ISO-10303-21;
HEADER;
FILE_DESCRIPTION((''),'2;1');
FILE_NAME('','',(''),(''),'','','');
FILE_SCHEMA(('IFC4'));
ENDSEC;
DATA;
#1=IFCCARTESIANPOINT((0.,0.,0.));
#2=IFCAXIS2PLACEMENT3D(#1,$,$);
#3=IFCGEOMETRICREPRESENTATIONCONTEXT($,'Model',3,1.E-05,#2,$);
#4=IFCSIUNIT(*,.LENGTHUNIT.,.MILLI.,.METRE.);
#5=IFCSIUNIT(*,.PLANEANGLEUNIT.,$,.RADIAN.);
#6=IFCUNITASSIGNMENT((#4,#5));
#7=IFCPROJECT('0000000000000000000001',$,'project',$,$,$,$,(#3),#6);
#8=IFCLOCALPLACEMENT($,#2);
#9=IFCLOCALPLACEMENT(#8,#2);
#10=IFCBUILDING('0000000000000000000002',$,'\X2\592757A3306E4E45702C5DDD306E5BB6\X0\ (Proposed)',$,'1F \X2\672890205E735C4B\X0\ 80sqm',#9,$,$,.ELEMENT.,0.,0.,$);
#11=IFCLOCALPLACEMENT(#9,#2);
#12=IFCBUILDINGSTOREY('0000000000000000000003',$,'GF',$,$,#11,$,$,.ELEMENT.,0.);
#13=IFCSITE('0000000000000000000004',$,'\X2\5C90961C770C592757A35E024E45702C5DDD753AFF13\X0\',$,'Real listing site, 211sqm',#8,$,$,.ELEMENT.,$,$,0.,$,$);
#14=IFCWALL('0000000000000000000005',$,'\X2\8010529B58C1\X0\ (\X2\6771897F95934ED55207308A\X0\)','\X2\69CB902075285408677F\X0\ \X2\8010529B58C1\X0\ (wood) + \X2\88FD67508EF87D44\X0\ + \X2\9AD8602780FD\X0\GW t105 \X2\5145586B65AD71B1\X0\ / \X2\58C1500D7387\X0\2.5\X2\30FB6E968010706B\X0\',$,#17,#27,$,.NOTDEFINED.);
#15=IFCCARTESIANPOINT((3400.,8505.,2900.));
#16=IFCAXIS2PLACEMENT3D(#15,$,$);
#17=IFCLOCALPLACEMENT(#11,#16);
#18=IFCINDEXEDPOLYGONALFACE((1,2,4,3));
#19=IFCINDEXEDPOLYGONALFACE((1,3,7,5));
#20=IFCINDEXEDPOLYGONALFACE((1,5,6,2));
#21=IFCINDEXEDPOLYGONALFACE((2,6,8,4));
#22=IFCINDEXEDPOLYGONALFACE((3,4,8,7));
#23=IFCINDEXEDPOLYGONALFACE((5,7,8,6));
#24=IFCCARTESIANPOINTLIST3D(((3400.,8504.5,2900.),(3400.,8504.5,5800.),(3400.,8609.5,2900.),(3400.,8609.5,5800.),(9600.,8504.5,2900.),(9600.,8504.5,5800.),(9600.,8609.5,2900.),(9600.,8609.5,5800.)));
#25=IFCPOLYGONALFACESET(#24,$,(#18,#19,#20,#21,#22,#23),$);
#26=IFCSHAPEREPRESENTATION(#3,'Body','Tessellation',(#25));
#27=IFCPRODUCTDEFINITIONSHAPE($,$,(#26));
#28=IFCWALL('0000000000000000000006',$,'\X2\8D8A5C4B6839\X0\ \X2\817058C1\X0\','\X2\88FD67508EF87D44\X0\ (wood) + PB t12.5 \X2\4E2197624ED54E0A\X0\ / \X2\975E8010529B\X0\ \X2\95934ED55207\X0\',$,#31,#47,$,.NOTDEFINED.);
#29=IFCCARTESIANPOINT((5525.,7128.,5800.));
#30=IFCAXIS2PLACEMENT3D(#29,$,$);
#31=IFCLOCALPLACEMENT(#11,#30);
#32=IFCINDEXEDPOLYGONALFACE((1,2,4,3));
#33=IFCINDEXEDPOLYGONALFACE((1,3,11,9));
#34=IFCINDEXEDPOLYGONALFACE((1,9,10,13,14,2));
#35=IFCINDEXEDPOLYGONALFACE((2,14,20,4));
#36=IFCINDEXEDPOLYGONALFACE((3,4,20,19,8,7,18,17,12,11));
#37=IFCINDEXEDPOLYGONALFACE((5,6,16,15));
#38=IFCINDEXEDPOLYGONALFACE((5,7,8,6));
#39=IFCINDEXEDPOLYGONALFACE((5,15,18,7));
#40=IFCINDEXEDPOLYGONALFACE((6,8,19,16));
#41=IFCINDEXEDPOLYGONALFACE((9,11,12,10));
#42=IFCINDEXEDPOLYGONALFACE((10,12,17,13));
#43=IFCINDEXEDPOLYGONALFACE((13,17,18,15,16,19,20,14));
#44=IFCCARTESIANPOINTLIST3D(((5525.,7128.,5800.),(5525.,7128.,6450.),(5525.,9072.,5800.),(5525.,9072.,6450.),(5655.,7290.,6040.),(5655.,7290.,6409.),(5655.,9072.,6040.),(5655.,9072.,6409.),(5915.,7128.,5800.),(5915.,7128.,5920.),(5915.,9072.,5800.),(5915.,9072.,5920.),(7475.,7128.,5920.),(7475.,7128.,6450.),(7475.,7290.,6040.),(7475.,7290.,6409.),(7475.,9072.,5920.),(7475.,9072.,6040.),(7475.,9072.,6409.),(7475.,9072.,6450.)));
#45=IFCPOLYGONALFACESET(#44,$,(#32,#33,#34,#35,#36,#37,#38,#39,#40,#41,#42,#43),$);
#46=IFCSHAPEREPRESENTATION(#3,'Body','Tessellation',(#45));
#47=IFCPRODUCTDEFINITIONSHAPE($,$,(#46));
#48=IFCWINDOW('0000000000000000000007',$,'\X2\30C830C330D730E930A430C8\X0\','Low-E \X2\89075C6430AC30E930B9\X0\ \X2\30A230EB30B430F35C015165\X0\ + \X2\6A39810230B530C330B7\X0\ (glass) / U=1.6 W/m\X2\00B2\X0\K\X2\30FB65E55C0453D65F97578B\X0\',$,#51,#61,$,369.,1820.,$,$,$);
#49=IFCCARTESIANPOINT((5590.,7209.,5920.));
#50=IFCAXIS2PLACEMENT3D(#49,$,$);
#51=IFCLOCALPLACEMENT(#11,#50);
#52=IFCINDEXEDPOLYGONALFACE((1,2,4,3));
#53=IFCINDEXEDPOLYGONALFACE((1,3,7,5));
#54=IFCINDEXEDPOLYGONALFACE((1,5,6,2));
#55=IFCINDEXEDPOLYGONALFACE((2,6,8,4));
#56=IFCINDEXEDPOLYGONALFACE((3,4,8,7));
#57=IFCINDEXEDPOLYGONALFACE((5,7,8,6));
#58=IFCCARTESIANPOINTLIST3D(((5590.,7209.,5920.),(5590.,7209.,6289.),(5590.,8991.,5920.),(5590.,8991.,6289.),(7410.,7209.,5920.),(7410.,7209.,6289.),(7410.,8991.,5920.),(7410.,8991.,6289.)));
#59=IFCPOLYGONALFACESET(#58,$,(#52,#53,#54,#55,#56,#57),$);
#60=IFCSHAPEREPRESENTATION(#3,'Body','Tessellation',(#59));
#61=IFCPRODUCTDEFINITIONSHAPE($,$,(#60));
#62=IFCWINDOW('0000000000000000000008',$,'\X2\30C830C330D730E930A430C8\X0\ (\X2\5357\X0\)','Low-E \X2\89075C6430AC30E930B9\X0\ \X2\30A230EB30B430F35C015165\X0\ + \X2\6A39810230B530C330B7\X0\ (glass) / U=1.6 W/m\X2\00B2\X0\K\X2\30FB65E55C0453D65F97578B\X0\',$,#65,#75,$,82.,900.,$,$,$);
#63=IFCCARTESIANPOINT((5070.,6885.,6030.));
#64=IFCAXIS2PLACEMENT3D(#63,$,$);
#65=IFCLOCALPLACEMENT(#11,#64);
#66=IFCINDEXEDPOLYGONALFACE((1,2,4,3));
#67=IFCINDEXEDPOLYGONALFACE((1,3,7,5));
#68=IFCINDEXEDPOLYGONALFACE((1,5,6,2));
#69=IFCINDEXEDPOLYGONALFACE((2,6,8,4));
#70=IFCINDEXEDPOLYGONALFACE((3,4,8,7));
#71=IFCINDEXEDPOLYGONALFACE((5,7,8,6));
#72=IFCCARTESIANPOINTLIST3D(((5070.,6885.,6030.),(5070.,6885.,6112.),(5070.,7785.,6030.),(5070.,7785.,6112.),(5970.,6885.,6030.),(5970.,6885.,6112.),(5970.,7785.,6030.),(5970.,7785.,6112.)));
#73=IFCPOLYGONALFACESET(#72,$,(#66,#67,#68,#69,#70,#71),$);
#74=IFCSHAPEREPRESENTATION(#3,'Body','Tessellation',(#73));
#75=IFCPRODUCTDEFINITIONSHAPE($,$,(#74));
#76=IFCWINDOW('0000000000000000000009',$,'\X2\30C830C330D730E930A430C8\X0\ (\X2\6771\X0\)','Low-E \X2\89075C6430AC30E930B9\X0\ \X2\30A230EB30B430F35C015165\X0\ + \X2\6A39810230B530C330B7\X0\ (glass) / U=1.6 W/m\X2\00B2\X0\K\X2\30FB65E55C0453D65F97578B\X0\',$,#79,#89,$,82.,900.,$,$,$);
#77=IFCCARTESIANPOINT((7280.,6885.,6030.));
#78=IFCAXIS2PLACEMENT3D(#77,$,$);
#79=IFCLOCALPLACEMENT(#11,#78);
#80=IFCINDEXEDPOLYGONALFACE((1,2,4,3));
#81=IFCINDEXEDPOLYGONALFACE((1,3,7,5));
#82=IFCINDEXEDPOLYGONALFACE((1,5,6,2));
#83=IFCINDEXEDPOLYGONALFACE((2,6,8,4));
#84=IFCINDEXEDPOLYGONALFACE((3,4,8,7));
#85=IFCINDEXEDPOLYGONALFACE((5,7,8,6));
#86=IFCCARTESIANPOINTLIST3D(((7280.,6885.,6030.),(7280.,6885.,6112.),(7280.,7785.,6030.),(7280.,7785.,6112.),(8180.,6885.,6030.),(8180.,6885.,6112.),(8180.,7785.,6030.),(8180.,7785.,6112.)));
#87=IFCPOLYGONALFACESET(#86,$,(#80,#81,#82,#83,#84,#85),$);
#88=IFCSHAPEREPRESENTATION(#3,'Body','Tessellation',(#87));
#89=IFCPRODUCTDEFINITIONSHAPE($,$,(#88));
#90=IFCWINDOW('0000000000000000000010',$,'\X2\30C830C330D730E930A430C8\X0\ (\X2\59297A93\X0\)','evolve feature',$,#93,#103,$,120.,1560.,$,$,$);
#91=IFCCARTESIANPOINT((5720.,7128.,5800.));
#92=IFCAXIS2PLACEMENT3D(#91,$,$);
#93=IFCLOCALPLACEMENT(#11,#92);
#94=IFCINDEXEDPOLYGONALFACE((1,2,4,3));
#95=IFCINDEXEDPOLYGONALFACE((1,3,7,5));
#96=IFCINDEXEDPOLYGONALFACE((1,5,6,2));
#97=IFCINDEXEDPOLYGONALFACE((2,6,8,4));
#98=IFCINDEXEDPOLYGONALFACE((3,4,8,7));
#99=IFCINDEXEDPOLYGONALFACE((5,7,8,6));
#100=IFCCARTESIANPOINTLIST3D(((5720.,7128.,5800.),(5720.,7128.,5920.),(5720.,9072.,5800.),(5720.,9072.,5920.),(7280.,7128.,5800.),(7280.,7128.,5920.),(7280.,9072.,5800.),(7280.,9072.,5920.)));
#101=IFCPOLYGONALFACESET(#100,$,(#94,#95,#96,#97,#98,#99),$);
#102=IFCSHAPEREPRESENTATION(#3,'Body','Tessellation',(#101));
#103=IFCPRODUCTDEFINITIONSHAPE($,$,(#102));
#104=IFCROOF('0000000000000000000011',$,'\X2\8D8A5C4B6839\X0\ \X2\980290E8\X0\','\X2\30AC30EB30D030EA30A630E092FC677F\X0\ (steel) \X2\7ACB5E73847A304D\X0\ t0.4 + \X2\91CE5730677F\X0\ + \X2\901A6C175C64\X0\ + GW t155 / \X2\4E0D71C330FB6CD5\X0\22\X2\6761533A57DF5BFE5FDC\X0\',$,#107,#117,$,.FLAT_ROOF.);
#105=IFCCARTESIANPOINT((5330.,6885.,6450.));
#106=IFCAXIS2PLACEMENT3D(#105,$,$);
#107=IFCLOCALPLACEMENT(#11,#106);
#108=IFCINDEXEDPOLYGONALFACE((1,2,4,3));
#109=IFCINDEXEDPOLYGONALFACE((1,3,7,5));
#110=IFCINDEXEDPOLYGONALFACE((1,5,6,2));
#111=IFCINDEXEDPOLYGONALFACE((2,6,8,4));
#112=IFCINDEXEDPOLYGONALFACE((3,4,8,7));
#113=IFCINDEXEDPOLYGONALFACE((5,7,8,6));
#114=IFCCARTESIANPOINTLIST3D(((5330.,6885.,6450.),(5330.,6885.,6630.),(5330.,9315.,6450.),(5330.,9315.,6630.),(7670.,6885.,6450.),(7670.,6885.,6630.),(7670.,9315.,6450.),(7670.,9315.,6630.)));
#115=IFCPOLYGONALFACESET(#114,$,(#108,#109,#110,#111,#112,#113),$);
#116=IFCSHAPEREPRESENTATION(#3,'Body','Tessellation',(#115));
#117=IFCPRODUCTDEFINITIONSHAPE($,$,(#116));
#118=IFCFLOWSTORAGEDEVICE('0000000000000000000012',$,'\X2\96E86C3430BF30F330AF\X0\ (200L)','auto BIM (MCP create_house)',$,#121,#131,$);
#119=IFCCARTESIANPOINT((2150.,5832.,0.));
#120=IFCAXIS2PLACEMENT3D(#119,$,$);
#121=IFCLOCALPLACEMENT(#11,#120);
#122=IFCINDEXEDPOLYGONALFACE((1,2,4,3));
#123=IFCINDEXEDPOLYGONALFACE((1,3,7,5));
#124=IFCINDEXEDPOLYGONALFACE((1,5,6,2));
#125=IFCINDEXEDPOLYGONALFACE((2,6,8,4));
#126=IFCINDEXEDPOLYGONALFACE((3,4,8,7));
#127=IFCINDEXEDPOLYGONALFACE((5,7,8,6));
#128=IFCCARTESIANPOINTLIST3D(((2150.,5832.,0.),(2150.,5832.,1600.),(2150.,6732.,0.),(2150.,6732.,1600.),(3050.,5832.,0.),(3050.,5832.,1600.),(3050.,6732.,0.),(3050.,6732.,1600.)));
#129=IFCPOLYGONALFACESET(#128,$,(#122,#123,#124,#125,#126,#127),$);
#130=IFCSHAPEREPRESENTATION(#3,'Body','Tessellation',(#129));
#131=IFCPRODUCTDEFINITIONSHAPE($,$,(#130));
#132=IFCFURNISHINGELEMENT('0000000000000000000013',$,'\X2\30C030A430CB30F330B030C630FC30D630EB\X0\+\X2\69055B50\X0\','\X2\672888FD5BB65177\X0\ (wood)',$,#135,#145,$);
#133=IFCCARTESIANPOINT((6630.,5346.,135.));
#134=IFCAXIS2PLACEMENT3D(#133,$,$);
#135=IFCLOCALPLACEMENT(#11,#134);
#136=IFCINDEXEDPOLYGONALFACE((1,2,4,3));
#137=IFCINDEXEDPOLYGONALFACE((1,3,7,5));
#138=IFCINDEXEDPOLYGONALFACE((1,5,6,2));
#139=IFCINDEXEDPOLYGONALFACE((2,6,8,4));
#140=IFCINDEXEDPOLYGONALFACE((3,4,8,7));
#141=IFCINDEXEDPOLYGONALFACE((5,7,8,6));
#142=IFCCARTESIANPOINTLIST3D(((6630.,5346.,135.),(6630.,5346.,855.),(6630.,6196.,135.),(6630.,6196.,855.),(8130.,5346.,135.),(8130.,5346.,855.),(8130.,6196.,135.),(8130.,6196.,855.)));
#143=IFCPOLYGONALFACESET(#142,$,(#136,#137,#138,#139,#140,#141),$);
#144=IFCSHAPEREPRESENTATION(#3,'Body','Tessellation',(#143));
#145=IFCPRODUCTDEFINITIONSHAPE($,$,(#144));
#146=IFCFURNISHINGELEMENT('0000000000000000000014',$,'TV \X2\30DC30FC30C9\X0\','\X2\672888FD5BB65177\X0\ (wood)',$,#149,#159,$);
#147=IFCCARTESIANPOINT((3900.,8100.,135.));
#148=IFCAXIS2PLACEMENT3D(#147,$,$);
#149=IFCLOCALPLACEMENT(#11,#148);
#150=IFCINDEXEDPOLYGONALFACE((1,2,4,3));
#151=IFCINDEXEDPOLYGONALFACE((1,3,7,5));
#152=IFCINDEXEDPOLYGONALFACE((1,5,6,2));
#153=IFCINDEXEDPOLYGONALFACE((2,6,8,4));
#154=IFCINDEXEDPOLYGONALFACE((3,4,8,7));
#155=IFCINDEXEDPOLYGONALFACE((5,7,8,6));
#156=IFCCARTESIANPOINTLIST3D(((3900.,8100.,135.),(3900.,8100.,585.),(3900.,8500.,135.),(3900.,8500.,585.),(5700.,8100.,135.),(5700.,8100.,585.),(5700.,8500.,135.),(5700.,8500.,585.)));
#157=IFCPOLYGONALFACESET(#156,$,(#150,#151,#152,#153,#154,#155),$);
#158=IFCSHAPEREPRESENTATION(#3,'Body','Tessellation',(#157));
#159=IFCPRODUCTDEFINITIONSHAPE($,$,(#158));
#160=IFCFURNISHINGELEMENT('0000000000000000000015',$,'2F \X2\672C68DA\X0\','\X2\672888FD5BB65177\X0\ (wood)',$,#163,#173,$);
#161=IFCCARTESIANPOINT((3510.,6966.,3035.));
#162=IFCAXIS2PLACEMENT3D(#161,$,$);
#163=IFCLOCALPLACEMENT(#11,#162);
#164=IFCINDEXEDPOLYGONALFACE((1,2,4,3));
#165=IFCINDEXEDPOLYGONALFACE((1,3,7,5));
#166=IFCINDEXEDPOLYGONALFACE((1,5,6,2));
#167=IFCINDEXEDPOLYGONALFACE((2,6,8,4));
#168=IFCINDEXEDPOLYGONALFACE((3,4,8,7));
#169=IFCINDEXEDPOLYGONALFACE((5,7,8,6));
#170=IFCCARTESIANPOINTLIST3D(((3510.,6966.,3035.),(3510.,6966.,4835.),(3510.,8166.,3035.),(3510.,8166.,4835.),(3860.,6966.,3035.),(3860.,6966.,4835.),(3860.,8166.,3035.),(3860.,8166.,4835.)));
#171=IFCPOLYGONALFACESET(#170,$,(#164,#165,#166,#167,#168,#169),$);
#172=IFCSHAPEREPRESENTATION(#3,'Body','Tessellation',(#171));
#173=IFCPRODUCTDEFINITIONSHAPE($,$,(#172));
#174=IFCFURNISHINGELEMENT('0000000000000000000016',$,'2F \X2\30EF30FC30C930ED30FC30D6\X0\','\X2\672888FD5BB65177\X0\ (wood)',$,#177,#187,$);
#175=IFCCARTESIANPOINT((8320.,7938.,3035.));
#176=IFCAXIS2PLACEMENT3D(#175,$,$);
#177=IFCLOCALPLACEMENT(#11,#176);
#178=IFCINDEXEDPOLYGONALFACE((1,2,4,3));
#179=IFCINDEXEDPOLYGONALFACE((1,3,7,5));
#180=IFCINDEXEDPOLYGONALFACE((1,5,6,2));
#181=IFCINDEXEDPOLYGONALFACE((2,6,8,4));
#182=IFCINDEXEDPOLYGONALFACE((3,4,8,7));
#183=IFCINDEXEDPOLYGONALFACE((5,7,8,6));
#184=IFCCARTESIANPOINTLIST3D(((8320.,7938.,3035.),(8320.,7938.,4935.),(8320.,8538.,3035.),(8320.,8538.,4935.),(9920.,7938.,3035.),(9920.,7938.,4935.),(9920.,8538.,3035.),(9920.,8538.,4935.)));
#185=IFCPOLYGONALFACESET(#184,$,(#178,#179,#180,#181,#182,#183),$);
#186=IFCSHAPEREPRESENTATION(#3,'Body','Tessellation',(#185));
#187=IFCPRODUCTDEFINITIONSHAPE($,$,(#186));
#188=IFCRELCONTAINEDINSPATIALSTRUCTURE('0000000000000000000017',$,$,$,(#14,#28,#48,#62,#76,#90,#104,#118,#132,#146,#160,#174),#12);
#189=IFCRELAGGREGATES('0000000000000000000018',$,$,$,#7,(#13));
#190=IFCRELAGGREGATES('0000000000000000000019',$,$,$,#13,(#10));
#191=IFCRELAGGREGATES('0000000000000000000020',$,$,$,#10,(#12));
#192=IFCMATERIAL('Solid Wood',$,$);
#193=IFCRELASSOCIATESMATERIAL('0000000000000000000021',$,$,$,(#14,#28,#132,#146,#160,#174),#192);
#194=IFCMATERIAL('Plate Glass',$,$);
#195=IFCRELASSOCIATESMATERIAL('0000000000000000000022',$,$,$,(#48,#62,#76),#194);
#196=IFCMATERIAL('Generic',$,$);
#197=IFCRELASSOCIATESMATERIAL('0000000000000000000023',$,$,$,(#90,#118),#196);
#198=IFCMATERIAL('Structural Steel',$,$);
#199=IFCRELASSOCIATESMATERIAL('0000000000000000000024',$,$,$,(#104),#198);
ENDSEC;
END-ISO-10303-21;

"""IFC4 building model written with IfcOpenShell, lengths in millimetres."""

from ifc_helpers import new_model, si_unit, frame, frame_2d, origin, place, context, project, spatial, rectangle, extrude, material, element, fill, save


model = new_model("IFC4")

# Units and contexts
model_context = context("Model", 3, precision=1e-05, world=origin())
ifc_project = project(units=[si_unit("LENGTHUNIT", "METRE", prefix="MILLI"), si_unit("PLANEANGLEUNIT", "RADIAN")], contexts=[model_context])

# Site, building, storey
site_placement = place(None, origin())
site = spatial("IfcSite", under=ifc_project, at=site_placement, Name="岐阜県大垣市久瀬川町３", ObjectType="Real listing site, 211sqm", CompositionType="ELEMENT", RefElevation=0.0)
building_placement = place(site_placement, origin())
building = spatial("IfcBuilding", under=site, at=building_placement, Name="大垣の久瀬川の家 (Proposed)", ObjectType="1F 木造平屋 80sqm", CompositionType="ELEMENT", ElevationOfRefHeight=0.0, ElevationOfTerrain=0.0)
storey_placement = place(building_placement, origin())
storey = spatial("IfcBuildingStorey", under=building, at=storey_placement, Name="GF", CompositionType="ELEMENT", Elevation=0.0)

# Wall
ifc_material_1 = material(Name="Solid Wood")
wall_1_placement = place(storey_placement, frame((3400.0, 8505.0, 2900.0)))
element("IfcWall", 1, at=wall_1_placement, inside=storey, material=ifc_material_1, Name="耐力壁 (東西間仕切り)", Description="構造用合板 耐力壁 (wood) + 製材軸組 + 高性能GW t105 充填断熱 / 壁倍率2.5・準耐火", PredefinedType="NOTDEFINED", context=model_context, shape_type="SweptSolid", body=[
    extrude(rectangle(XDim=6200.0, YDim=105.0, at=frame_2d((3100.0, 52.0))), frame((3400.0, 8505.0, 2900.0)), (0.0, 0.0, 1.0), 2900.0),
])

# Wall, openings, windows
wall_2_placement = place(storey_placement, frame((5525.0, 7128.0, 5800.0)))
wall_2 = element("IfcWall", 2, at=wall_2_placement, inside=storey, material=ifc_material_1, Name="越屋根 腰壁", Description="製材軸組 (wood) + PB t12.5 両面仕上 / 非耐力 間仕切", PredefinedType="NOTDEFINED", context=model_context, shape_type="SweptSolid", body=[
    extrude(rectangle(XDim=1950.0, YDim=1944.0, at=frame_2d((975.0, 972.0))), frame((5525.0, 7128.0, 5800.0)), (0.0, 0.0, 1.0), 650.0),
])
opening_1_placement = place(storey_placement, frame((5590.0, 7209.0, 5920.0)))
opening_1 = element("IfcOpeningElement", 3, at=opening_1_placement, cuts=wall_2, PredefinedType="NOTDEFINED", context=model_context, shape_type="SweptSolid", body=[
    extrude(rectangle(XDim=1820.0, YDim=1782.0, at=frame_2d((910.0, 891.0))), frame((5590.0, 7209.0, 5920.0)), (0.0, 0.0, 1.0), 369.0),
])
opening_2_placement = place(storey_placement, frame((5070.0, 6885.0, 6030.0)))
opening_2 = element("IfcOpeningElement", 4, at=opening_2_placement, cuts=wall_2, PredefinedType="NOTDEFINED", context=model_context, shape_type="SweptSolid", body=[
    extrude(rectangle(XDim=900.0, YDim=900.0, at=frame_2d((450.0, 450.0))), frame((5070.0, 6885.0, 6030.0)), (0.0, 0.0, 1.0), 82.0),
])
opening_3_placement = place(storey_placement, frame((7280.0, 6885.0, 6030.0)))
opening_3 = element("IfcOpeningElement", 5, at=opening_3_placement, cuts=wall_2, PredefinedType="NOTDEFINED", context=model_context, shape_type="SweptSolid", body=[
    extrude(rectangle(XDim=900.0, YDim=900.0, at=frame_2d((450.0, 450.0))), frame((7280.0, 6885.0, 6030.0)), (0.0, 0.0, 1.0), 82.0),
])
opening_4_placement = place(storey_placement, frame((5720.0, 7128.0, 5800.0)))
opening_4 = element("IfcOpeningElement", 6, at=opening_4_placement, cuts=wall_2, PredefinedType="NOTDEFINED", context=model_context, shape_type="SweptSolid", body=[
    extrude(rectangle(XDim=1560.0, YDim=1944.0, at=frame_2d((780.0, 972.0))), frame((5720.0, 7128.0, 5800.0)), (0.0, 0.0, 1.0), 120.0),
])
ifc_material_2 = material(Name="Plate Glass")
window_1_placement = place(storey_placement, frame((5590.0, 7209.0, 5920.0)))
window_1 = element("IfcWindow", 7, at=window_1_placement, inside=storey, material=ifc_material_2, Name="トップライト", Description="Low-E 複層ガラス アルゴン封入 + 樹脂サッシ (glass) / U=1.6 W/m²K・日射取得型", OverallHeight=369.0, OverallWidth=1820.0, context=model_context, shape_type="SweptSolid", body=[
    extrude(rectangle(XDim=1820.0, YDim=1782.0, at=frame_2d((910.0, 891.0))), frame((5590.0, 7209.0, 5920.0)), (0.0, 0.0, 1.0), 369.0),
])
fill(opening_1, window_1)
window_2_placement = place(storey_placement, frame((5070.0, 6885.0, 6030.0)))
window_2 = element("IfcWindow", 8, at=window_2_placement, inside=storey, material=ifc_material_2, Name="トップライト (南)", Description="Low-E 複層ガラス アルゴン封入 + 樹脂サッシ (glass) / U=1.6 W/m²K・日射取得型", OverallHeight=82.0, OverallWidth=900.0, context=model_context, shape_type="SweptSolid", body=[
    extrude(rectangle(XDim=900.0, YDim=900.0, at=frame_2d((450.0, 450.0))), frame((5070.0, 6885.0, 6030.0)), (0.0, 0.0, 1.0), 82.0),
])
fill(opening_2, window_2)
window_3_placement = place(storey_placement, frame((7280.0, 6885.0, 6030.0)))
window_3 = element("IfcWindow", 9, at=window_3_placement, inside=storey, material=ifc_material_2, Name="トップライト (東)", Description="Low-E 複層ガラス アルゴン封入 + 樹脂サッシ (glass) / U=1.6 W/m²K・日射取得型", OverallHeight=82.0, OverallWidth=900.0, context=model_context, shape_type="SweptSolid", body=[
    extrude(rectangle(XDim=900.0, YDim=900.0, at=frame_2d((450.0, 450.0))), frame((7280.0, 6885.0, 6030.0)), (0.0, 0.0, 1.0), 82.0),
])
fill(opening_3, window_3)
ifc_material_3 = material(Name="Generic")
window_4_placement = place(storey_placement, frame((5720.0, 7128.0, 5800.0)))
window_4 = element("IfcWindow", 10, at=window_4_placement, inside=storey, material=ifc_material_3, Name="トップライト (天窓)", Description="evolve feature", OverallHeight=120.0, OverallWidth=1560.0, context=model_context, shape_type="SweptSolid", body=[
    extrude(rectangle(XDim=1560.0, YDim=1944.0, at=frame_2d((780.0, 972.0))), frame((5720.0, 7128.0, 5800.0)), (0.0, 0.0, 1.0), 120.0),
])
fill(opening_4, window_4)

# Roof
ifc_material_4 = material(Name="Structural Steel")
roof_placement = place(storey_placement, frame((5330.0, 6885.0, 6450.0)))
element("IfcRoof", 11, at=roof_placement, inside=storey, material=ifc_material_4, Name="越屋根 頂部", Description="ガルバリウム鋼板 (steel) 立平葺き t0.4 + 野地板 + 通気層 + GW t155 / 不燃・法22条区域対応", PredefinedType="FLAT_ROOF", context=model_context, shape_type="SweptSolid", body=[
    extrude(rectangle(XDim=2340.0, YDim=2430.0, at=frame_2d((1170.0, 1215.0))), frame((5330.0, 6885.0, 6450.0)), (0.0, 0.0, 1.0), 180.0),
])

# Flow storage device
flow_storage_device_placement = place(storey_placement, frame((2150.0, 5832.0, 0.0)))
element("IfcFlowStorageDevice", 12, at=flow_storage_device_placement, inside=storey, material=ifc_material_3, Name="雨水タンク (200L)", Description="auto BIM (MCP create_house)", context=model_context, shape_type="SweptSolid", body=[
    extrude(rectangle(XDim=900.0, YDim=900.0, at=frame_2d((450.0, 450.0))), frame((2150.0, 5832.0, 0.0)), (0.0, 0.0, 1.0), 1600.0),
])

# Furnishing elements
furnishing_1_placement = place(storey_placement, frame((6630.0, 5346.0, 135.0)))
element("IfcFurnishingElement", 13, at=furnishing_1_placement, inside=storey, material=ifc_material_1, Name="ダイニングテーブル+椅子", Description="木製家具 (wood)", context=model_context, shape_type="SweptSolid", body=[
    extrude(rectangle(XDim=1500.0, YDim=850.0, at=frame_2d((750.0, 425.0))), frame((6630.0, 5346.0, 135.0)), (0.0, 0.0, 1.0), 720.0),
])
furnishing_2_placement = place(storey_placement, frame((3900.0, 8100.0, 135.0)))
element("IfcFurnishingElement", 14, at=furnishing_2_placement, inside=storey, material=ifc_material_1, Name="TV ボード", Description="木製家具 (wood)", context=model_context, shape_type="SweptSolid", body=[
    extrude(rectangle(XDim=1800.0, YDim=400.0, at=frame_2d((900.0, 200.0))), frame((3900.0, 8100.0, 135.0)), (0.0, 0.0, 1.0), 450.0),
])
furnishing_3_placement = place(storey_placement, frame((3510.0, 6966.0, 3035.0)))
element("IfcFurnishingElement", 15, at=furnishing_3_placement, inside=storey, material=ifc_material_1, Name="2F 本棚", Description="木製家具 (wood)", context=model_context, shape_type="SweptSolid", body=[
    extrude(rectangle(XDim=350.0, YDim=1200.0, at=frame_2d((175.0, 600.0))), frame((3510.0, 6966.0, 3035.0)), (0.0, 0.0, 1.0), 1800.0),
])
furnishing_4_placement = place(storey_placement, frame((8320.0, 7938.0, 3035.0)))
element("IfcFurnishingElement", 16, at=furnishing_4_placement, inside=storey, material=ifc_material_1, Name="2F ワードローブ", Description="木製家具 (wood)", context=model_context, shape_type="SweptSolid", body=[
    extrude(rectangle(XDim=1600.0, YDim=600.0, at=frame_2d((800.0, 300.0))), frame((8320.0, 7938.0, 3035.0)), (0.0, 0.0, 1.0), 1900.0),
])

save(model, "model.ifc")
